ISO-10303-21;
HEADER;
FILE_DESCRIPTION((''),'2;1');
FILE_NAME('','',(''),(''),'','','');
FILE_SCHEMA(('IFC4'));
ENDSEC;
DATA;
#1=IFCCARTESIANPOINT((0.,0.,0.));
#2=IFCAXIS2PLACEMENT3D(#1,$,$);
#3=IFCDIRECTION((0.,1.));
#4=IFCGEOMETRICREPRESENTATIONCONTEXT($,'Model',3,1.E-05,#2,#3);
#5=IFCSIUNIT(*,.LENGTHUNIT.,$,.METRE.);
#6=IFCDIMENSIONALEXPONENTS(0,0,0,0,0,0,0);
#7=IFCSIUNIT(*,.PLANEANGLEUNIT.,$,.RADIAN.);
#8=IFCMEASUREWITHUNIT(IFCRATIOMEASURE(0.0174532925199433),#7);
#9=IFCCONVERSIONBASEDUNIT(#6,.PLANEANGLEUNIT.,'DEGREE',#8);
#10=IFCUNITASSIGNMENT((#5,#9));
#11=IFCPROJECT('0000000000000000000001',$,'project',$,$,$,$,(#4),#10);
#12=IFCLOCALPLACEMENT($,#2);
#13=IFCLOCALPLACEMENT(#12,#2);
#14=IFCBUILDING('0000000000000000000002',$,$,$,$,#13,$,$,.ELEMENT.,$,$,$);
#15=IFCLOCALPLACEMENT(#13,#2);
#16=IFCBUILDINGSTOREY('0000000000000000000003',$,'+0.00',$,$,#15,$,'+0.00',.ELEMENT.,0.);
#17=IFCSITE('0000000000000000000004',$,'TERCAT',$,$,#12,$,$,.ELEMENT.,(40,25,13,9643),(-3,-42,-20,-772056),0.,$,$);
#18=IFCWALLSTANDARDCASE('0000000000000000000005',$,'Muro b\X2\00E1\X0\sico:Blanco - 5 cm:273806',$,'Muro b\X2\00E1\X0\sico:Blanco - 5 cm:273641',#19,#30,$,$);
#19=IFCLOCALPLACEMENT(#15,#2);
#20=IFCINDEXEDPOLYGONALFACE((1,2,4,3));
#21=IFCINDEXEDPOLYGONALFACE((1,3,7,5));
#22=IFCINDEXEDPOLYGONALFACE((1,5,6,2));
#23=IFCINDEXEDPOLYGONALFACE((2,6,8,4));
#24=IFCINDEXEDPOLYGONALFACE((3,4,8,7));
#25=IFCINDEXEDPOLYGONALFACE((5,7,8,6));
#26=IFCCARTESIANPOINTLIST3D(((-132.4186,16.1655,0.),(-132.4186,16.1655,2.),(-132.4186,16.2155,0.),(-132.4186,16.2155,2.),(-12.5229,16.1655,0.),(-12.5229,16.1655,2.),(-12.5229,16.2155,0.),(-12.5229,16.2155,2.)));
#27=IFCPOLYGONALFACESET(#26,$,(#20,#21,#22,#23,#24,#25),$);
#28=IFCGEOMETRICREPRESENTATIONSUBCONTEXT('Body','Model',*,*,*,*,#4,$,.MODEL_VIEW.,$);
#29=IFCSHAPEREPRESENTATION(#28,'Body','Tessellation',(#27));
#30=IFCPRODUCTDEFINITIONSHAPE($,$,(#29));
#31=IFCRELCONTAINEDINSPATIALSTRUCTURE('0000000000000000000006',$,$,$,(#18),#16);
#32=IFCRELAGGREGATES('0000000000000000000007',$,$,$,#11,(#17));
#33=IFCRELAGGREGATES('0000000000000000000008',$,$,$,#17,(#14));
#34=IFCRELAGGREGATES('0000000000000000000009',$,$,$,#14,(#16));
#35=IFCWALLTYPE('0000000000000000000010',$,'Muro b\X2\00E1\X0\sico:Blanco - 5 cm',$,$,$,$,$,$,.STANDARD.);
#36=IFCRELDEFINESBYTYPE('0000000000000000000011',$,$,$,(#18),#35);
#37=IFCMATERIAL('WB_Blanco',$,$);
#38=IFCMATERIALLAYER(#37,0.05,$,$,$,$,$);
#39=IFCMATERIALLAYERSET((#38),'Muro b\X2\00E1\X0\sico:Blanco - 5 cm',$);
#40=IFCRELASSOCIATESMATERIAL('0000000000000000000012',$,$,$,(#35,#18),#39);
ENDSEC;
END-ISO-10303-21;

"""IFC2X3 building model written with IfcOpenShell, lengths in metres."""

from ifc_helpers import new_model, entity, si_unit, converted_unit, direction, frame, frame_2d, origin, place, context, subcontext, project, spatial, rectangle, extrude, material, layer, layer_set, layer_usage, type_object, element, save


model = new_model("IFC2X3")

# Units and contexts
model_context = context("Model", 3, precision=1e-05, world=origin(), true_north=direction((0.0, 1.0)))
body_context = subcontext(model_context, "Body", "Model", "MODEL_VIEW")
ifc_project = project(units=[si_unit("LENGTHUNIT", "METRE"), converted_unit("PLANEANGLEUNIT", "DEGREE", entity("IfcRatioMeasure", 0.0174532925199433), si_unit("PLANEANGLEUNIT", "RADIAN"), dimensions=[0, 0, 0, 0, 0, 0, 0])], contexts=[model_context])

# Site, building, storey
site_placement = place(None, origin())
site = spatial("IfcSite", under=ifc_project, at=site_placement, Name="TERCAT", CompositionType="ELEMENT", RefLatitude=(40, 25, 13, 9643), RefLongitude=(-3, -42, -20, -772056), RefElevation=0.0)
building_placement = place(site_placement, origin())
building = spatial("IfcBuilding", under=site, at=building_placement, CompositionType="ELEMENT")
storey_placement = place(building_placement, origin())
storey = spatial("IfcBuildingStorey", under=building, at=storey_placement, Name="+0.00", LongName="+0.00", CompositionType="ELEMENT", Elevation=0.0)

# Wall
ifc_material_1 = material(Name="WB_Blanco")
ifc_layer_1 = layer(ifc_material_1, 0.05)
ifc_layer_set_1 = layer_set([ifc_layer_1], Name="Muro básico:Blanco - 5 cm")
ifc_layer_usage_1 = layer_usage(ifc_layer_set_1, "AXIS2", "POSITIVE", -0.025)
wall_type_1 = type_object("IfcWallType", Name="Muro básico:Blanco - 5 cm", PredefinedType="STANDARD", material=ifc_layer_set_1)
wall_1_placement = place(storey_placement, frame((-132.4186, 16.1905, 0.0)))
element("IfcWallStandardCase", 1, at=wall_1_placement, inside=storey, type_object=wall_type_1, material=ifc_layer_usage_1, Name="Muro básico:Blanco - 5 cm:273806", ObjectType="Muro básico:Blanco - 5 cm:273641", context=body_context, shape_type="SweptSolid", body=[
    extrude(rectangle(XDim=119.8957, YDim=0.05, at=frame_2d((59.9478, 0.0), x_axis=(-1.0, 0.0))), origin(), (0.0, 0.0, 1.0), 2.0),
])

save(model, "model.ifc")
